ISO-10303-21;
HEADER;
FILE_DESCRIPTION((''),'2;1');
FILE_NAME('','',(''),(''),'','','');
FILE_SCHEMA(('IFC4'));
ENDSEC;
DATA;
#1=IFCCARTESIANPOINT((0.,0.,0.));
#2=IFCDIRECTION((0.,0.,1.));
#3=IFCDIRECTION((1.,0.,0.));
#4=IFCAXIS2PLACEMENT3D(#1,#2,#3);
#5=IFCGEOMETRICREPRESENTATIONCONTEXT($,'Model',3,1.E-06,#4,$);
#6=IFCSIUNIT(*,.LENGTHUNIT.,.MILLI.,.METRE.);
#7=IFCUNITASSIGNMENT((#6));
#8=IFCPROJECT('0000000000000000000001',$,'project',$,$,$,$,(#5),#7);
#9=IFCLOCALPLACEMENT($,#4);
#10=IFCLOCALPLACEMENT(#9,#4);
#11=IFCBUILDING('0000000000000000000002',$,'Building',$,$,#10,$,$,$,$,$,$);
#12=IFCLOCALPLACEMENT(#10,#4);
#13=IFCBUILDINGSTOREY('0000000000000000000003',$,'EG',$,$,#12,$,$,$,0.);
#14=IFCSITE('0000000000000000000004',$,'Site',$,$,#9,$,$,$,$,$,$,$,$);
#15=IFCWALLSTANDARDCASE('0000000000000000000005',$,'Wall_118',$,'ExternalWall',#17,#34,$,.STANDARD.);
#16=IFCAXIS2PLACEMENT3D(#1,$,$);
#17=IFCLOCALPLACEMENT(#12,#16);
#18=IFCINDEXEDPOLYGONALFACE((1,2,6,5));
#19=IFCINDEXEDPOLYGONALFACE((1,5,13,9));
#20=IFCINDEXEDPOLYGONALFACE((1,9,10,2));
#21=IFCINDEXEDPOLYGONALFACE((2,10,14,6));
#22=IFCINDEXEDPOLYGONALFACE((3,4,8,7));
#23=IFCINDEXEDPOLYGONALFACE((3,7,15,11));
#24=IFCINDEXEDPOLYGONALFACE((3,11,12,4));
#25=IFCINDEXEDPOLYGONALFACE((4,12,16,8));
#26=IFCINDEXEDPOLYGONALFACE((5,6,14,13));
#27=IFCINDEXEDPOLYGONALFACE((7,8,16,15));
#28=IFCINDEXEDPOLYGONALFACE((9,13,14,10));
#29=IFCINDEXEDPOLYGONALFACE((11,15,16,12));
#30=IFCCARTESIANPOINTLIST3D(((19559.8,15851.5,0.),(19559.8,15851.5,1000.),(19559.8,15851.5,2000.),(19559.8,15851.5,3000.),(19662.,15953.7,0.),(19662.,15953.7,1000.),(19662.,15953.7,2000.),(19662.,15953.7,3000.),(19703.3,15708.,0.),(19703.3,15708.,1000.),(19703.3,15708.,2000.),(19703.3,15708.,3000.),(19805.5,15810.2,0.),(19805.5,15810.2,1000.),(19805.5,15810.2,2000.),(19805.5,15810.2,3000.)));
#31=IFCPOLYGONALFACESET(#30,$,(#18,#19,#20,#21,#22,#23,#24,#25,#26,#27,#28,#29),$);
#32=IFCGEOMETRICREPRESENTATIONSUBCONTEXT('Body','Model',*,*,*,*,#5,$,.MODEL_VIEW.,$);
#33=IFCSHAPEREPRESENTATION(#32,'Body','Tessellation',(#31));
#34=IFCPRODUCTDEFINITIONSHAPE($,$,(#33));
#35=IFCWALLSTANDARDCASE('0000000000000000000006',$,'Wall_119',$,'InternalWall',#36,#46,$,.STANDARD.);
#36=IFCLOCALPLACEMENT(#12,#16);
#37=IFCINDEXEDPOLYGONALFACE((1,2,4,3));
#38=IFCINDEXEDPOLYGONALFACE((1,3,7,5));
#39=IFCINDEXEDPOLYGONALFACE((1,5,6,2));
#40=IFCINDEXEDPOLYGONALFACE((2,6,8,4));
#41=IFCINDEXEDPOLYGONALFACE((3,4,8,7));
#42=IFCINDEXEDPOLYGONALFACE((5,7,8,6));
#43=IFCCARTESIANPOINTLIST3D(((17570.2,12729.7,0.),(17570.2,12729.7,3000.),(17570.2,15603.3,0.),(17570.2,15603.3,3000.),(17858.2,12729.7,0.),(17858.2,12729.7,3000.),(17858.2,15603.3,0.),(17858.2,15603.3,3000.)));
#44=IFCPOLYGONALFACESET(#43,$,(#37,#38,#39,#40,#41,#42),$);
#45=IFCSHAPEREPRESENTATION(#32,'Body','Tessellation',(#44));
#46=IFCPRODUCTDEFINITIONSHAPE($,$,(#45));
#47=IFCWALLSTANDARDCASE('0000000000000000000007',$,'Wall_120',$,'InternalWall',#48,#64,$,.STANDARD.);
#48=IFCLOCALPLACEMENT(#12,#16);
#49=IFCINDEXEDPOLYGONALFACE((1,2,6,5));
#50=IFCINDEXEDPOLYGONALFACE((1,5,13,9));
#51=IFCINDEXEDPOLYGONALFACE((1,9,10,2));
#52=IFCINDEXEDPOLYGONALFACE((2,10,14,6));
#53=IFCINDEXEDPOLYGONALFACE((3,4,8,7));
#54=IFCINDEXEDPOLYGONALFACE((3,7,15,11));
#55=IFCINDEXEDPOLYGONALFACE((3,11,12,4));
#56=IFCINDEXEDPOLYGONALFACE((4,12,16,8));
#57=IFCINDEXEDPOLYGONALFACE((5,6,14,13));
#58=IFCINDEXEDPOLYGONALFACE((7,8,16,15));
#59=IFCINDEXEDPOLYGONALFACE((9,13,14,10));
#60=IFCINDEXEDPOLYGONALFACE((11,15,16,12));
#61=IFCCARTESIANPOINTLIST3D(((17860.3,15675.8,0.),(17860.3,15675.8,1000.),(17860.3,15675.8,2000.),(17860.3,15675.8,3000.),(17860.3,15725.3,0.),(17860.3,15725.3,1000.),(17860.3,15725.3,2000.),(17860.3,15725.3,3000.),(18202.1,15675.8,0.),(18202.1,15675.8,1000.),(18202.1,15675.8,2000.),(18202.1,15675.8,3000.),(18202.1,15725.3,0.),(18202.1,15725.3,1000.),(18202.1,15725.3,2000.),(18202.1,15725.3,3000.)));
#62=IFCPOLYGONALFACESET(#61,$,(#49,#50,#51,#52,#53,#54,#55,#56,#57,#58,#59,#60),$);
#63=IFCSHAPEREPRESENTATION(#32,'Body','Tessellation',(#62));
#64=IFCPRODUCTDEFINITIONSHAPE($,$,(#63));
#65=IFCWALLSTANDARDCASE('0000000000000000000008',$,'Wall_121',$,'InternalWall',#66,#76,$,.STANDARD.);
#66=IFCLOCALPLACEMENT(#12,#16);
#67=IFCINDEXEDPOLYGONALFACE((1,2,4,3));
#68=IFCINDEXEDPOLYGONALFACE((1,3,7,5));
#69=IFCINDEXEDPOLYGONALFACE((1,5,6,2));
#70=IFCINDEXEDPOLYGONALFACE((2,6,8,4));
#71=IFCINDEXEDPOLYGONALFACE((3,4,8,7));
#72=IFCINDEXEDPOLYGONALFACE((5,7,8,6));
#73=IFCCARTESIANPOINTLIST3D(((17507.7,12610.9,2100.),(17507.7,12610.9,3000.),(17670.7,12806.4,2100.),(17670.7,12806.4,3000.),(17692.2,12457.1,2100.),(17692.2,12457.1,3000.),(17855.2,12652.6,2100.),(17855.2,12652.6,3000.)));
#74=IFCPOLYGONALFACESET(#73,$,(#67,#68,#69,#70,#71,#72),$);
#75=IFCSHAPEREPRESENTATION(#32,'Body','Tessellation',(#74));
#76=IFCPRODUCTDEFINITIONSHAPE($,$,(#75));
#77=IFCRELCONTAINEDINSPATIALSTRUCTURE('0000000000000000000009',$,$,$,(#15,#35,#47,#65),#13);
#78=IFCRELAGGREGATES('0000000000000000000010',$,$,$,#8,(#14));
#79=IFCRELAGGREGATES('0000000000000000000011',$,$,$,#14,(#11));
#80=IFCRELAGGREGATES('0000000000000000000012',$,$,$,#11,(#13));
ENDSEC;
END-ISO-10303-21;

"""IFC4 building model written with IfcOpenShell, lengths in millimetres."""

from ifc_helpers import new_model, si_unit, frame, origin_with_axes, place, context, subcontext, project, spatial, rectangle, extrude, element, save


model = new_model("IFC4")

# Units and contexts
model_context = context("Model", 3, precision=1e-06, world=origin_with_axes())
body_context = subcontext(model_context, "Body", "Model", "MODEL_VIEW")
ifc_project = project(units=[si_unit("LENGTHUNIT", "METRE", prefix="MILLI")], contexts=[model_context])

# Site, building, storey
site_placement = place(None, origin_with_axes())
site = spatial("IfcSite", under=ifc_project, at=site_placement, Name="Site")
building_placement = place(site_placement, origin_with_axes())
building = spatial("IfcBuilding", under=site, at=building_placement, Name="Building")
storey_placement = place(building_placement, origin_with_axes())
storey = spatial("IfcBuildingStorey", under=building, at=storey_placement, Name="EG", Elevation=0.0)

# Wall, opening
wall_1_placement = place(storey_placement, origin_with_axes())
wall_1 = element("IfcWallStandardCase", 1, at=wall_1_placement, inside=storey, Name="Wall_118", ObjectType="ExternalWall", PredefinedType="STANDARD", context=body_context, shape_type="SweptSolid", body=[
    extrude(rectangle(XDim=202.9, YDim=144.5), frame((19682.6, 15830.8, 0.0), z_axis=(0.0, 0.0, 1.0), x_axis=(-0.707107, 0.707107, 0.0)), (0.0, 0.0, 1.0), 3000.0),
])
opening_1_placement = place(wall_1_placement, origin_with_axes())
element("IfcOpeningElement", 2, at=opening_1_placement, inside=storey, cuts=wall_1, context=body_context, shape_type="SweptSolid", body=[
    extrude(rectangle(XDim=600.0, YDim=144.5), frame((19676.1, 15837.4, 1000.0), z_axis=(0.0, 0.0, 1.0), x_axis=(-0.707107, 0.707107, 0.0)), (0.0, 0.0, 1.0), 1000.0),
])

# Wall
wall_2_placement = place(storey_placement, origin_with_axes())
element("IfcWallStandardCase", 3, at=wall_2_placement, inside=storey, Name="Wall_119", ObjectType="InternalWall", PredefinedType="STANDARD", context=body_context, shape_type="SweptSolid", body=[
    extrude(rectangle(XDim=2873.7, YDim=288.0), frame((17714.2, 14166.5, 0.0), z_axis=(0.0, 0.0, 1.0), x_axis=(0.0, -1.0, 0.0)), (0.0, 0.0, 1.0), 3000.0),
])

# Walls, openings
wall_3_placement = place(storey_placement, origin_with_axes())
wall_3 = element("IfcWallStandardCase", 4, at=wall_3_placement, inside=storey, Name="Wall_120", ObjectType="InternalWall", PredefinedType="STANDARD", context=body_context, shape_type="SweptSolid", body=[
    extrude(rectangle(XDim=341.7, YDim=49.5), frame((18031.2, 15700.5, 0.0), z_axis=(0.0, 0.0, 1.0), x_axis=(1.0, 0.0, 0.0)), (0.0, 0.0, 1.0), 3000.0),
])
opening_2_placement = place(wall_3_placement, origin_with_axes())
element("IfcOpeningElement", 5, at=opening_2_placement, inside=storey, cuts=wall_3, context=body_context, shape_type="SweptSolid", body=[
    extrude(rectangle(XDim=600.0, YDim=49.5), frame((18031.2, 15700.5, 1000.0), z_axis=(0.0, 0.0, 1.0), x_axis=(1.0, 0.0, 0.0)), (0.0, 0.0, 1.0), 1000.0),
])
wall_4_placement = place(storey_placement, origin_with_axes())
wall_4 = element("IfcWallStandardCase", 6, at=wall_4_placement, inside=storey, Name="Wall_121", ObjectType="InternalWall", PredefinedType="STANDARD", context=body_context, shape_type="SweptSolid", body=[
    extrude(rectangle(XDim=254.5, YDim=240.2), frame((17681.4, 12631.8, 0.0), z_axis=(0.0, 0.0, 1.0), x_axis=(-0.640378, -0.76806, 0.0)), (0.0, 0.0, 1.0), 3000.0),
])
opening_3_placement = place(wall_4_placement, origin_with_axes())
element("IfcOpeningElement", 7, at=opening_3_placement, inside=storey, cuts=wall_4, context=body_context, shape_type="SweptSolid", body=[
    extrude(rectangle(XDim=450.0, YDim=240.2), frame((17681.4, 12631.8, 0.0), z_axis=(0.0, 0.0, 1.0), x_axis=(-0.640378, -0.76806, 0.0)), (0.0, 0.0, 1.0), 2100.0),
])

save(model, "model.ifc")
